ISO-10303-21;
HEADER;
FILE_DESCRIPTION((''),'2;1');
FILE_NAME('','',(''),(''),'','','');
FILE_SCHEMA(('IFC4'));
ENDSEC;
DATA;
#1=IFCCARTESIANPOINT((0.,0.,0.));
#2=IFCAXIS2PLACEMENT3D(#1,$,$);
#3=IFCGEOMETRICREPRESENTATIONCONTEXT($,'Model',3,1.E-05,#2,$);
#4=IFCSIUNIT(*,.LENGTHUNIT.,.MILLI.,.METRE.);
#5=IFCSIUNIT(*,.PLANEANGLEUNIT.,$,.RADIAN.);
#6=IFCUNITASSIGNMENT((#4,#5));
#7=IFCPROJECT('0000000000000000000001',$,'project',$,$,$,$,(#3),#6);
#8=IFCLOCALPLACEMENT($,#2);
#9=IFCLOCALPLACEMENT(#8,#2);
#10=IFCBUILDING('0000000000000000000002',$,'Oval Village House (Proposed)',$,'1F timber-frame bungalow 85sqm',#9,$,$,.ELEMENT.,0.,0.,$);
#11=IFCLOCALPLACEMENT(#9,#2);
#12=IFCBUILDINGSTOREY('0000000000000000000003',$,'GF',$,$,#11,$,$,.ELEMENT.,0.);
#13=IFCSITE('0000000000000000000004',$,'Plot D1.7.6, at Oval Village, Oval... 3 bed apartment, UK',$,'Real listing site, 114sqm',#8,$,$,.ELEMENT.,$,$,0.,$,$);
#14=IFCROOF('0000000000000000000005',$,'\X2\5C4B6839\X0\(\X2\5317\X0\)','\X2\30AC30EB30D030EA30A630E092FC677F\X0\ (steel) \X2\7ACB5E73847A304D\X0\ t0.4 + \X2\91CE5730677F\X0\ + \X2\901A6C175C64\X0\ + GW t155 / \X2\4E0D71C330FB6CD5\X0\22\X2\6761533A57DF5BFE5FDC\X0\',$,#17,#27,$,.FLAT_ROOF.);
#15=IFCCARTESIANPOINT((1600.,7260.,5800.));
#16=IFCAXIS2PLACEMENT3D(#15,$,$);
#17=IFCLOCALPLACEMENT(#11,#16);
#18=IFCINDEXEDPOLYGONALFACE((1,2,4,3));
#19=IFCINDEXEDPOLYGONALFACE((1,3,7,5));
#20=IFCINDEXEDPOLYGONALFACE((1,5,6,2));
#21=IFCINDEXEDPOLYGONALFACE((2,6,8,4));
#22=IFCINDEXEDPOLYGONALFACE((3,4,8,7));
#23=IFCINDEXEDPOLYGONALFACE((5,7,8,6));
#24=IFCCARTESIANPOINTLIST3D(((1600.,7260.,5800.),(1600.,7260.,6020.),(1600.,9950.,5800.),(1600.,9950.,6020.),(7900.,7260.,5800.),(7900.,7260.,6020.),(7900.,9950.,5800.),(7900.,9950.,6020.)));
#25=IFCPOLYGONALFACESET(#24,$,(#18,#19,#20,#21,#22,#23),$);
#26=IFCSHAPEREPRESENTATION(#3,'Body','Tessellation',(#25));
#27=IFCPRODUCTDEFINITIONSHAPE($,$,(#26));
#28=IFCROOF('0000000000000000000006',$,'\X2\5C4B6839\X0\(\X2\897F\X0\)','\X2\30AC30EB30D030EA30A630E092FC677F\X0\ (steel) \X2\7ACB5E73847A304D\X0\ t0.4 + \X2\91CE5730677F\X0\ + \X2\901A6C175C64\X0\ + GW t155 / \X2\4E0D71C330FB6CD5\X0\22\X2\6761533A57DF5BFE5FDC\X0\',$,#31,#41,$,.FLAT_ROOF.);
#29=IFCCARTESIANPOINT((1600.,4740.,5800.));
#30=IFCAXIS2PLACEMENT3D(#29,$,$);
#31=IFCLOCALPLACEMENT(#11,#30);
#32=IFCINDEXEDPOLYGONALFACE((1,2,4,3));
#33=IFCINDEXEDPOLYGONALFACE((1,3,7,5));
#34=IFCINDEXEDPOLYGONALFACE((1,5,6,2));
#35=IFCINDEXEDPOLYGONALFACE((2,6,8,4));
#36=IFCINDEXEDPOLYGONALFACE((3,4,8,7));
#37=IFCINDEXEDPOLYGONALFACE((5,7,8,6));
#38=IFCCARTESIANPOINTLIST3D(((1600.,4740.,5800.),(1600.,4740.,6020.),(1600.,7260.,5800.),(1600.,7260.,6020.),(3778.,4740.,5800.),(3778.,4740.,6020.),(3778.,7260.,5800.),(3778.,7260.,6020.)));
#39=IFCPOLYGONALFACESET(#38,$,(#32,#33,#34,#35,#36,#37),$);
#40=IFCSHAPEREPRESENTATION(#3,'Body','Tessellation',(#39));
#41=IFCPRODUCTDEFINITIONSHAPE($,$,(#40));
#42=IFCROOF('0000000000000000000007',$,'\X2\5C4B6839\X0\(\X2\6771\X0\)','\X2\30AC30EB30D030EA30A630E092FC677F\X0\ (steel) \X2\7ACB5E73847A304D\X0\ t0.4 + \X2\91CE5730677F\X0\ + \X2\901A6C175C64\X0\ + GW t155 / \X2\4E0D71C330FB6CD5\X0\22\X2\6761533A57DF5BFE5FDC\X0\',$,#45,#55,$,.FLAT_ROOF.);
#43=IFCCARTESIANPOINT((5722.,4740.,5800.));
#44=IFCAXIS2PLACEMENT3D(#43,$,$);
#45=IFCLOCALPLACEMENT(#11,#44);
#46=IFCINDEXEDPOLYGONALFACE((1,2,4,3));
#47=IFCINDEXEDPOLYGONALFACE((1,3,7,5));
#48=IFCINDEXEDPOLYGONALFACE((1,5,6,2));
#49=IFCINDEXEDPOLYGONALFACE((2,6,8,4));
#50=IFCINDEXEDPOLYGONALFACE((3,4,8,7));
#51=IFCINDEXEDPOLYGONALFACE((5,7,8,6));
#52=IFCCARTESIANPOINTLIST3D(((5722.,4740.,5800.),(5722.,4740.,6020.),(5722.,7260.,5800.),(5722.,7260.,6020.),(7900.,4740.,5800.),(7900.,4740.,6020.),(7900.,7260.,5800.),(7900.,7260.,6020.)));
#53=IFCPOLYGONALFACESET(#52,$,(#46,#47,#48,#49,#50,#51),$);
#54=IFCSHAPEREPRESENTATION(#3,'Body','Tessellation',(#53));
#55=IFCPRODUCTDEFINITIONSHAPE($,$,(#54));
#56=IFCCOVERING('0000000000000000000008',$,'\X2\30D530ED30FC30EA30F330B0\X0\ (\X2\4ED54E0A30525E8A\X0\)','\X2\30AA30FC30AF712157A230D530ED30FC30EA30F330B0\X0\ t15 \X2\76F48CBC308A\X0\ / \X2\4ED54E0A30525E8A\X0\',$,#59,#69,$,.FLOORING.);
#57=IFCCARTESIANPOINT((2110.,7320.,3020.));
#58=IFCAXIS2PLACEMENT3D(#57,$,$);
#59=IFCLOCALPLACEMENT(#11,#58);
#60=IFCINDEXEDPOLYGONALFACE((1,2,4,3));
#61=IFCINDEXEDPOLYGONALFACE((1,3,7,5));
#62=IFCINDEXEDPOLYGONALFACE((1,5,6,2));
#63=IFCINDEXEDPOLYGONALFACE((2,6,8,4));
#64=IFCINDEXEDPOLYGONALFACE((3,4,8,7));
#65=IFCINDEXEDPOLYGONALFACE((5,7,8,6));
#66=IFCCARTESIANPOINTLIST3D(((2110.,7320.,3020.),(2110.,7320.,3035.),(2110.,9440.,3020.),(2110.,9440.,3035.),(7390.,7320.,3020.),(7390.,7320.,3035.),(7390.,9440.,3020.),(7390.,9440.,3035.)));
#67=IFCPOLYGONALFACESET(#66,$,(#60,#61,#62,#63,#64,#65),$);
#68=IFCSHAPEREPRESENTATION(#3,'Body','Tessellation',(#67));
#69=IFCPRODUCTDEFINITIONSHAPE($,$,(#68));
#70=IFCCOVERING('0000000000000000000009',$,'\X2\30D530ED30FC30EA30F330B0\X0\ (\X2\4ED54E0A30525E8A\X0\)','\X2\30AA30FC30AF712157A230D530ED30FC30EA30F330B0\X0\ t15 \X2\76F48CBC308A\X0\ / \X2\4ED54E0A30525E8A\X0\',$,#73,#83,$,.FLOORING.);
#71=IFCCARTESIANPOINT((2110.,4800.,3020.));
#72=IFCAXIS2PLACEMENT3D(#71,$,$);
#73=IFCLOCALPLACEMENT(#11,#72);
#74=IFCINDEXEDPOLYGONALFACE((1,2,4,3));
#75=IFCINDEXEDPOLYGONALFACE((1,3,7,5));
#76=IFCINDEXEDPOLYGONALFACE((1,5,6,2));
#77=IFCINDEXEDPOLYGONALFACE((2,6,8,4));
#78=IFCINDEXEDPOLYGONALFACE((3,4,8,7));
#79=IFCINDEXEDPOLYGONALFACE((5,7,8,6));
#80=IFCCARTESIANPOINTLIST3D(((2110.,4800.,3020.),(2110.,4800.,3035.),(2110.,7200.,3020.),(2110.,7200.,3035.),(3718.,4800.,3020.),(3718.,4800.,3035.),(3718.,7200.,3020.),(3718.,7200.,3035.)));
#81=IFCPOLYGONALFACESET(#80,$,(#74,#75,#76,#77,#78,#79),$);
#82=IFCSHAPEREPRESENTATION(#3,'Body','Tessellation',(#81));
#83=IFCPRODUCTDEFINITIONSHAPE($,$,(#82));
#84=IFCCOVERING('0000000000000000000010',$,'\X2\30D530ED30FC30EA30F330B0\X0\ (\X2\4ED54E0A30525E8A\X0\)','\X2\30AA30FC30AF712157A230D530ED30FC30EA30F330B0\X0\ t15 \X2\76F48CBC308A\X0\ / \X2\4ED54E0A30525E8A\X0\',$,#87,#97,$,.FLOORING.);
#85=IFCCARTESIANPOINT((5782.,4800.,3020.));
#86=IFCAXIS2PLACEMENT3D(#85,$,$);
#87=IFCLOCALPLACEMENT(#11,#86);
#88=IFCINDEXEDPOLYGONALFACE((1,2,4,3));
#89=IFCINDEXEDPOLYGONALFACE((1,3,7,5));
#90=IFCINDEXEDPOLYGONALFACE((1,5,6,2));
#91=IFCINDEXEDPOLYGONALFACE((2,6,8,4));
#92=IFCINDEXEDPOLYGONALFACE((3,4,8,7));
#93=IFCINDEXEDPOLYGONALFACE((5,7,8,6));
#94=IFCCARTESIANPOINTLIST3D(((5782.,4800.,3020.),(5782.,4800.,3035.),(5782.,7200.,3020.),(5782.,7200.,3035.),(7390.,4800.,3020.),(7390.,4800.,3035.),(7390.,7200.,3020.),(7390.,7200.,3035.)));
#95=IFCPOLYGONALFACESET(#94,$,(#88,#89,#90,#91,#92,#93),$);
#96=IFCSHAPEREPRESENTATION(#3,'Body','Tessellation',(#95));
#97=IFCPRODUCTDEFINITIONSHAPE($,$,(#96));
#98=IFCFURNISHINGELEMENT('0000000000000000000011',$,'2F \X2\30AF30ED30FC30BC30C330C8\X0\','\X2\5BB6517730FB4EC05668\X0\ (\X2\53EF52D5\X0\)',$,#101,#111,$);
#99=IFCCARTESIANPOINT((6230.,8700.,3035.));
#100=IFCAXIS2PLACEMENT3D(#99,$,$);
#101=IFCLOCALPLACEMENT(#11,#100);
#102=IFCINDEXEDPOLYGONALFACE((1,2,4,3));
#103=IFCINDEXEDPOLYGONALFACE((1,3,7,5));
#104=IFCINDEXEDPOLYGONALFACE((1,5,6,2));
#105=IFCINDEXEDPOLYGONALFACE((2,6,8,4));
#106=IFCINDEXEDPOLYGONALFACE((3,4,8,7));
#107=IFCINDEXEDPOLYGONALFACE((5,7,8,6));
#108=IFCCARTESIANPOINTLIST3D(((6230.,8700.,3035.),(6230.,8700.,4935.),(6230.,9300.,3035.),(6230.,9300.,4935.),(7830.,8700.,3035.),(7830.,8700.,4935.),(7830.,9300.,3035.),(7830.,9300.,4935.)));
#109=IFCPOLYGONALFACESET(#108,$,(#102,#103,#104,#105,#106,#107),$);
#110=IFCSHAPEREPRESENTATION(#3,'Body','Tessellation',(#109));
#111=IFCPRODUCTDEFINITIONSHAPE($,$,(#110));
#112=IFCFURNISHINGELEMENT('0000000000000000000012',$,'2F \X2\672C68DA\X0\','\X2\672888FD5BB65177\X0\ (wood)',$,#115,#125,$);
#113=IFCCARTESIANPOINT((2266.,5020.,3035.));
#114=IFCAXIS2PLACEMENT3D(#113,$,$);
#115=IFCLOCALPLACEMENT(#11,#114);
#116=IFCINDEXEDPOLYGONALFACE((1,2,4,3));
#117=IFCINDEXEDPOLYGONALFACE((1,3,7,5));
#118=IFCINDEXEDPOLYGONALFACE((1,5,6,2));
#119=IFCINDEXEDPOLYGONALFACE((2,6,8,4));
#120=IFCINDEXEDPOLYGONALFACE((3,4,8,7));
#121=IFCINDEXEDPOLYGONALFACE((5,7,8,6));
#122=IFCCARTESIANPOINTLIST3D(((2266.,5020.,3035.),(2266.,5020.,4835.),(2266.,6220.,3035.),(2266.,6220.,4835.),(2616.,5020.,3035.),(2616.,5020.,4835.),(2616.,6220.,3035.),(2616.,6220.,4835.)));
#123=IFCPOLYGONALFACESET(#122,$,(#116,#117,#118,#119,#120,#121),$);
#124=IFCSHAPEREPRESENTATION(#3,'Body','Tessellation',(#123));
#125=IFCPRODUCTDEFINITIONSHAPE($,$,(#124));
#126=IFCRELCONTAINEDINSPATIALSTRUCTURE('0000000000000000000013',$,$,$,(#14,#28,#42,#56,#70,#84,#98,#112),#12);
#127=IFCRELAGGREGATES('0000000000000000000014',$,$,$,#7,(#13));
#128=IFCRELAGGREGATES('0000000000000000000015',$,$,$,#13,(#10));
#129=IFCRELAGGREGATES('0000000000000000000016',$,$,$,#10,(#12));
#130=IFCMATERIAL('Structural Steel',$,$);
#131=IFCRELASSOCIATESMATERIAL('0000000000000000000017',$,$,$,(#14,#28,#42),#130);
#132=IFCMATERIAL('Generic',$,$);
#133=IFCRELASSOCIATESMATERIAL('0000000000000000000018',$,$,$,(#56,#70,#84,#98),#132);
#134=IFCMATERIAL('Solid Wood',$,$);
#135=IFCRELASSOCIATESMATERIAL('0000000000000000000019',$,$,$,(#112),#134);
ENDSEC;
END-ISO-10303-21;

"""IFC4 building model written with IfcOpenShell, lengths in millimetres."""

from ifc_helpers import new_model, si_unit, frame, frame_2d, origin, place, context, project, spatial, rectangle, extrude, material, element, save


model = new_model("IFC4")

# Units and contexts
model_context = context("Model", 3, precision=1e-05, world=origin())
ifc_project = project(units=[si_unit("LENGTHUNIT", "METRE", prefix="MILLI"), si_unit("PLANEANGLEUNIT", "RADIAN")], contexts=[model_context])

# Site, building, storey
site_placement = place(None, origin())
site = spatial("IfcSite", under=ifc_project, at=site_placement, Name="Plot D1.7.6, at Oval Village, Oval... 3 bed apartment, UK", ObjectType="Real listing site, 114sqm", CompositionType="ELEMENT", RefElevation=0.0)
building_placement = place(site_placement, origin())
building = spatial("IfcBuilding", under=site, at=building_placement, Name="Oval Village House (Proposed)", ObjectType="1F timber-frame bungalow 85sqm", CompositionType="ELEMENT", ElevationOfRefHeight=0.0, ElevationOfTerrain=0.0)
storey_placement = place(building_placement, origin())
storey = spatial("IfcBuildingStorey", under=building, at=storey_placement, Name="GF", CompositionType="ELEMENT", Elevation=0.0)

# Shared definitions
ifc_material_1 = material(Name="Solid Wood")

# Shared definitions
ifc_material_2 = material(Name="Generic")

# Roofs
ifc_material_3 = material(Name="Structural Steel")
for number, where, name in (
    (1, (1600.0, 7260.0, 5800.0), "屋根(北)"),
):
    element("IfcRoof", number, at=place(storey_placement, frame(where)), inside=storey, material=ifc_material_3, Name=name, Description="ガルバリウム鋼板 (steel) 立平葺き t0.4 + 野地板 + 通気層 + GW t155 / 不燃・法22条区域対応", PredefinedType="FLAT_ROOF", context=model_context, shape_type="SweptSolid", body=[
        extrude(rectangle(XDim=6300.0, YDim=2690.0, at=frame_2d((3150.0, 1345.0))), frame((1600.0, 7260.0, 5800.0)), (0.0, 0.0, 1.0), 220.0),
    ])
roof_1_placement = place(storey_placement, frame((1600.0, 4740.0, 5800.0)))
element("IfcRoof", 2, at=roof_1_placement, inside=storey, material=ifc_material_3, Name="屋根(西)", Description="ガルバリウム鋼板 (steel) 立平葺き t0.4 + 野地板 + 通気層 + GW t155 / 不燃・法22条区域対応", PredefinedType="FLAT_ROOF", context=model_context, shape_type="SweptSolid", body=[
    extrude(rectangle(XDim=2178.0, YDim=2520.0, at=frame_2d((1089.0, 1260.0))), frame((1600.0, 4740.0, 5800.0)), (0.0, 0.0, 1.0), 220.0),
])
roof_2_placement = place(storey_placement, frame((5722.0, 4740.0, 5800.0)))
element("IfcRoof", 3, at=roof_2_placement, inside=storey, material=ifc_material_3, Name="屋根(東)", Description="ガルバリウム鋼板 (steel) 立平葺き t0.4 + 野地板 + 通気層 + GW t155 / 不燃・法22条区域対応", PredefinedType="FLAT_ROOF", context=model_context, shape_type="SweptSolid", body=[
    extrude(rectangle(XDim=2178.0, YDim=2520.0, at=frame_2d((1089.0, 1260.0))), frame((5722.0, 4740.0, 5800.0)), (0.0, 0.0, 1.0), 220.0),
])

# Coverings
covering_1_placement = place(storey_placement, frame((2110.0, 7320.0, 3020.0)))
element("IfcCovering", 4, at=covering_1_placement, inside=storey, material=ifc_material_2, Name="フローリング (仕上げ床)", Description="オーク無垢フローリング t15 直貼り / 仕上げ床", PredefinedType="FLOORING", context=model_context, shape_type="SweptSolid", body=[
    extrude(rectangle(XDim=5280.0, YDim=2120.0, at=frame_2d((2640.0, 1060.0))), frame((2110.0, 7320.0, 3020.0)), (0.0, 0.0, 1.0), 15.0),
])
covering_2_placement = place(storey_placement, frame((2110.0, 4800.0, 3020.0)))
element("IfcCovering", 5, at=covering_2_placement, inside=storey, material=ifc_material_2, Name="フローリング (仕上げ床)", Description="オーク無垢フローリング t15 直貼り / 仕上げ床", PredefinedType="FLOORING", context=model_context, shape_type="SweptSolid", body=[
    extrude(rectangle(XDim=1608.0, YDim=2400.0, at=frame_2d((804.0, 1200.0))), frame((2110.0, 4800.0, 3020.0)), (0.0, 0.0, 1.0), 15.0),
])
covering_3_placement = place(storey_placement, frame((5782.0, 4800.0, 3020.0)))
element("IfcCovering", 6, at=covering_3_placement, inside=storey, material=ifc_material_2, Name="フローリング (仕上げ床)", Description="オーク無垢フローリング t15 直貼り / 仕上げ床", PredefinedType="FLOORING", context=model_context, shape_type="SweptSolid", body=[
    extrude(rectangle(XDim=1608.0, YDim=2400.0, at=frame_2d((804.0, 1200.0))), frame((5782.0, 4800.0, 3020.0)), (0.0, 0.0, 1.0), 15.0),
])

# Furnishing elements
furnishing_1_placement = place(storey_placement, frame((6230.0, 8700.0, 3035.0)))
element("IfcFurnishingElement", 7, at=furnishing_1_placement, inside=storey, material=ifc_material_2, Name="2F クローゼット", Description="家具・什器 (可動)", context=model_context, shape_type="SweptSolid", body=[
    extrude(rectangle(XDim=1600.0, YDim=600.0, at=frame_2d((800.0, 300.0))), frame((6230.0, 8700.0, 3035.0)), (0.0, 0.0, 1.0), 1900.0),
])
furnishing_2_placement = place(storey_placement, frame((2266.0, 5020.0, 3035.0)))
element("IfcFurnishingElement", 8, at=furnishing_2_placement, inside=storey, material=ifc_material_1, Name="2F 本棚", Description="木製家具 (wood)", context=model_context, shape_type="SweptSolid", body=[
    extrude(rectangle(XDim=350.0, YDim=1200.0, at=frame_2d((175.0, 600.0))), frame((2266.0, 5020.0, 3035.0)), (0.0, 0.0, 1.0), 1800.0),
])

save(model, "model.ifc")
